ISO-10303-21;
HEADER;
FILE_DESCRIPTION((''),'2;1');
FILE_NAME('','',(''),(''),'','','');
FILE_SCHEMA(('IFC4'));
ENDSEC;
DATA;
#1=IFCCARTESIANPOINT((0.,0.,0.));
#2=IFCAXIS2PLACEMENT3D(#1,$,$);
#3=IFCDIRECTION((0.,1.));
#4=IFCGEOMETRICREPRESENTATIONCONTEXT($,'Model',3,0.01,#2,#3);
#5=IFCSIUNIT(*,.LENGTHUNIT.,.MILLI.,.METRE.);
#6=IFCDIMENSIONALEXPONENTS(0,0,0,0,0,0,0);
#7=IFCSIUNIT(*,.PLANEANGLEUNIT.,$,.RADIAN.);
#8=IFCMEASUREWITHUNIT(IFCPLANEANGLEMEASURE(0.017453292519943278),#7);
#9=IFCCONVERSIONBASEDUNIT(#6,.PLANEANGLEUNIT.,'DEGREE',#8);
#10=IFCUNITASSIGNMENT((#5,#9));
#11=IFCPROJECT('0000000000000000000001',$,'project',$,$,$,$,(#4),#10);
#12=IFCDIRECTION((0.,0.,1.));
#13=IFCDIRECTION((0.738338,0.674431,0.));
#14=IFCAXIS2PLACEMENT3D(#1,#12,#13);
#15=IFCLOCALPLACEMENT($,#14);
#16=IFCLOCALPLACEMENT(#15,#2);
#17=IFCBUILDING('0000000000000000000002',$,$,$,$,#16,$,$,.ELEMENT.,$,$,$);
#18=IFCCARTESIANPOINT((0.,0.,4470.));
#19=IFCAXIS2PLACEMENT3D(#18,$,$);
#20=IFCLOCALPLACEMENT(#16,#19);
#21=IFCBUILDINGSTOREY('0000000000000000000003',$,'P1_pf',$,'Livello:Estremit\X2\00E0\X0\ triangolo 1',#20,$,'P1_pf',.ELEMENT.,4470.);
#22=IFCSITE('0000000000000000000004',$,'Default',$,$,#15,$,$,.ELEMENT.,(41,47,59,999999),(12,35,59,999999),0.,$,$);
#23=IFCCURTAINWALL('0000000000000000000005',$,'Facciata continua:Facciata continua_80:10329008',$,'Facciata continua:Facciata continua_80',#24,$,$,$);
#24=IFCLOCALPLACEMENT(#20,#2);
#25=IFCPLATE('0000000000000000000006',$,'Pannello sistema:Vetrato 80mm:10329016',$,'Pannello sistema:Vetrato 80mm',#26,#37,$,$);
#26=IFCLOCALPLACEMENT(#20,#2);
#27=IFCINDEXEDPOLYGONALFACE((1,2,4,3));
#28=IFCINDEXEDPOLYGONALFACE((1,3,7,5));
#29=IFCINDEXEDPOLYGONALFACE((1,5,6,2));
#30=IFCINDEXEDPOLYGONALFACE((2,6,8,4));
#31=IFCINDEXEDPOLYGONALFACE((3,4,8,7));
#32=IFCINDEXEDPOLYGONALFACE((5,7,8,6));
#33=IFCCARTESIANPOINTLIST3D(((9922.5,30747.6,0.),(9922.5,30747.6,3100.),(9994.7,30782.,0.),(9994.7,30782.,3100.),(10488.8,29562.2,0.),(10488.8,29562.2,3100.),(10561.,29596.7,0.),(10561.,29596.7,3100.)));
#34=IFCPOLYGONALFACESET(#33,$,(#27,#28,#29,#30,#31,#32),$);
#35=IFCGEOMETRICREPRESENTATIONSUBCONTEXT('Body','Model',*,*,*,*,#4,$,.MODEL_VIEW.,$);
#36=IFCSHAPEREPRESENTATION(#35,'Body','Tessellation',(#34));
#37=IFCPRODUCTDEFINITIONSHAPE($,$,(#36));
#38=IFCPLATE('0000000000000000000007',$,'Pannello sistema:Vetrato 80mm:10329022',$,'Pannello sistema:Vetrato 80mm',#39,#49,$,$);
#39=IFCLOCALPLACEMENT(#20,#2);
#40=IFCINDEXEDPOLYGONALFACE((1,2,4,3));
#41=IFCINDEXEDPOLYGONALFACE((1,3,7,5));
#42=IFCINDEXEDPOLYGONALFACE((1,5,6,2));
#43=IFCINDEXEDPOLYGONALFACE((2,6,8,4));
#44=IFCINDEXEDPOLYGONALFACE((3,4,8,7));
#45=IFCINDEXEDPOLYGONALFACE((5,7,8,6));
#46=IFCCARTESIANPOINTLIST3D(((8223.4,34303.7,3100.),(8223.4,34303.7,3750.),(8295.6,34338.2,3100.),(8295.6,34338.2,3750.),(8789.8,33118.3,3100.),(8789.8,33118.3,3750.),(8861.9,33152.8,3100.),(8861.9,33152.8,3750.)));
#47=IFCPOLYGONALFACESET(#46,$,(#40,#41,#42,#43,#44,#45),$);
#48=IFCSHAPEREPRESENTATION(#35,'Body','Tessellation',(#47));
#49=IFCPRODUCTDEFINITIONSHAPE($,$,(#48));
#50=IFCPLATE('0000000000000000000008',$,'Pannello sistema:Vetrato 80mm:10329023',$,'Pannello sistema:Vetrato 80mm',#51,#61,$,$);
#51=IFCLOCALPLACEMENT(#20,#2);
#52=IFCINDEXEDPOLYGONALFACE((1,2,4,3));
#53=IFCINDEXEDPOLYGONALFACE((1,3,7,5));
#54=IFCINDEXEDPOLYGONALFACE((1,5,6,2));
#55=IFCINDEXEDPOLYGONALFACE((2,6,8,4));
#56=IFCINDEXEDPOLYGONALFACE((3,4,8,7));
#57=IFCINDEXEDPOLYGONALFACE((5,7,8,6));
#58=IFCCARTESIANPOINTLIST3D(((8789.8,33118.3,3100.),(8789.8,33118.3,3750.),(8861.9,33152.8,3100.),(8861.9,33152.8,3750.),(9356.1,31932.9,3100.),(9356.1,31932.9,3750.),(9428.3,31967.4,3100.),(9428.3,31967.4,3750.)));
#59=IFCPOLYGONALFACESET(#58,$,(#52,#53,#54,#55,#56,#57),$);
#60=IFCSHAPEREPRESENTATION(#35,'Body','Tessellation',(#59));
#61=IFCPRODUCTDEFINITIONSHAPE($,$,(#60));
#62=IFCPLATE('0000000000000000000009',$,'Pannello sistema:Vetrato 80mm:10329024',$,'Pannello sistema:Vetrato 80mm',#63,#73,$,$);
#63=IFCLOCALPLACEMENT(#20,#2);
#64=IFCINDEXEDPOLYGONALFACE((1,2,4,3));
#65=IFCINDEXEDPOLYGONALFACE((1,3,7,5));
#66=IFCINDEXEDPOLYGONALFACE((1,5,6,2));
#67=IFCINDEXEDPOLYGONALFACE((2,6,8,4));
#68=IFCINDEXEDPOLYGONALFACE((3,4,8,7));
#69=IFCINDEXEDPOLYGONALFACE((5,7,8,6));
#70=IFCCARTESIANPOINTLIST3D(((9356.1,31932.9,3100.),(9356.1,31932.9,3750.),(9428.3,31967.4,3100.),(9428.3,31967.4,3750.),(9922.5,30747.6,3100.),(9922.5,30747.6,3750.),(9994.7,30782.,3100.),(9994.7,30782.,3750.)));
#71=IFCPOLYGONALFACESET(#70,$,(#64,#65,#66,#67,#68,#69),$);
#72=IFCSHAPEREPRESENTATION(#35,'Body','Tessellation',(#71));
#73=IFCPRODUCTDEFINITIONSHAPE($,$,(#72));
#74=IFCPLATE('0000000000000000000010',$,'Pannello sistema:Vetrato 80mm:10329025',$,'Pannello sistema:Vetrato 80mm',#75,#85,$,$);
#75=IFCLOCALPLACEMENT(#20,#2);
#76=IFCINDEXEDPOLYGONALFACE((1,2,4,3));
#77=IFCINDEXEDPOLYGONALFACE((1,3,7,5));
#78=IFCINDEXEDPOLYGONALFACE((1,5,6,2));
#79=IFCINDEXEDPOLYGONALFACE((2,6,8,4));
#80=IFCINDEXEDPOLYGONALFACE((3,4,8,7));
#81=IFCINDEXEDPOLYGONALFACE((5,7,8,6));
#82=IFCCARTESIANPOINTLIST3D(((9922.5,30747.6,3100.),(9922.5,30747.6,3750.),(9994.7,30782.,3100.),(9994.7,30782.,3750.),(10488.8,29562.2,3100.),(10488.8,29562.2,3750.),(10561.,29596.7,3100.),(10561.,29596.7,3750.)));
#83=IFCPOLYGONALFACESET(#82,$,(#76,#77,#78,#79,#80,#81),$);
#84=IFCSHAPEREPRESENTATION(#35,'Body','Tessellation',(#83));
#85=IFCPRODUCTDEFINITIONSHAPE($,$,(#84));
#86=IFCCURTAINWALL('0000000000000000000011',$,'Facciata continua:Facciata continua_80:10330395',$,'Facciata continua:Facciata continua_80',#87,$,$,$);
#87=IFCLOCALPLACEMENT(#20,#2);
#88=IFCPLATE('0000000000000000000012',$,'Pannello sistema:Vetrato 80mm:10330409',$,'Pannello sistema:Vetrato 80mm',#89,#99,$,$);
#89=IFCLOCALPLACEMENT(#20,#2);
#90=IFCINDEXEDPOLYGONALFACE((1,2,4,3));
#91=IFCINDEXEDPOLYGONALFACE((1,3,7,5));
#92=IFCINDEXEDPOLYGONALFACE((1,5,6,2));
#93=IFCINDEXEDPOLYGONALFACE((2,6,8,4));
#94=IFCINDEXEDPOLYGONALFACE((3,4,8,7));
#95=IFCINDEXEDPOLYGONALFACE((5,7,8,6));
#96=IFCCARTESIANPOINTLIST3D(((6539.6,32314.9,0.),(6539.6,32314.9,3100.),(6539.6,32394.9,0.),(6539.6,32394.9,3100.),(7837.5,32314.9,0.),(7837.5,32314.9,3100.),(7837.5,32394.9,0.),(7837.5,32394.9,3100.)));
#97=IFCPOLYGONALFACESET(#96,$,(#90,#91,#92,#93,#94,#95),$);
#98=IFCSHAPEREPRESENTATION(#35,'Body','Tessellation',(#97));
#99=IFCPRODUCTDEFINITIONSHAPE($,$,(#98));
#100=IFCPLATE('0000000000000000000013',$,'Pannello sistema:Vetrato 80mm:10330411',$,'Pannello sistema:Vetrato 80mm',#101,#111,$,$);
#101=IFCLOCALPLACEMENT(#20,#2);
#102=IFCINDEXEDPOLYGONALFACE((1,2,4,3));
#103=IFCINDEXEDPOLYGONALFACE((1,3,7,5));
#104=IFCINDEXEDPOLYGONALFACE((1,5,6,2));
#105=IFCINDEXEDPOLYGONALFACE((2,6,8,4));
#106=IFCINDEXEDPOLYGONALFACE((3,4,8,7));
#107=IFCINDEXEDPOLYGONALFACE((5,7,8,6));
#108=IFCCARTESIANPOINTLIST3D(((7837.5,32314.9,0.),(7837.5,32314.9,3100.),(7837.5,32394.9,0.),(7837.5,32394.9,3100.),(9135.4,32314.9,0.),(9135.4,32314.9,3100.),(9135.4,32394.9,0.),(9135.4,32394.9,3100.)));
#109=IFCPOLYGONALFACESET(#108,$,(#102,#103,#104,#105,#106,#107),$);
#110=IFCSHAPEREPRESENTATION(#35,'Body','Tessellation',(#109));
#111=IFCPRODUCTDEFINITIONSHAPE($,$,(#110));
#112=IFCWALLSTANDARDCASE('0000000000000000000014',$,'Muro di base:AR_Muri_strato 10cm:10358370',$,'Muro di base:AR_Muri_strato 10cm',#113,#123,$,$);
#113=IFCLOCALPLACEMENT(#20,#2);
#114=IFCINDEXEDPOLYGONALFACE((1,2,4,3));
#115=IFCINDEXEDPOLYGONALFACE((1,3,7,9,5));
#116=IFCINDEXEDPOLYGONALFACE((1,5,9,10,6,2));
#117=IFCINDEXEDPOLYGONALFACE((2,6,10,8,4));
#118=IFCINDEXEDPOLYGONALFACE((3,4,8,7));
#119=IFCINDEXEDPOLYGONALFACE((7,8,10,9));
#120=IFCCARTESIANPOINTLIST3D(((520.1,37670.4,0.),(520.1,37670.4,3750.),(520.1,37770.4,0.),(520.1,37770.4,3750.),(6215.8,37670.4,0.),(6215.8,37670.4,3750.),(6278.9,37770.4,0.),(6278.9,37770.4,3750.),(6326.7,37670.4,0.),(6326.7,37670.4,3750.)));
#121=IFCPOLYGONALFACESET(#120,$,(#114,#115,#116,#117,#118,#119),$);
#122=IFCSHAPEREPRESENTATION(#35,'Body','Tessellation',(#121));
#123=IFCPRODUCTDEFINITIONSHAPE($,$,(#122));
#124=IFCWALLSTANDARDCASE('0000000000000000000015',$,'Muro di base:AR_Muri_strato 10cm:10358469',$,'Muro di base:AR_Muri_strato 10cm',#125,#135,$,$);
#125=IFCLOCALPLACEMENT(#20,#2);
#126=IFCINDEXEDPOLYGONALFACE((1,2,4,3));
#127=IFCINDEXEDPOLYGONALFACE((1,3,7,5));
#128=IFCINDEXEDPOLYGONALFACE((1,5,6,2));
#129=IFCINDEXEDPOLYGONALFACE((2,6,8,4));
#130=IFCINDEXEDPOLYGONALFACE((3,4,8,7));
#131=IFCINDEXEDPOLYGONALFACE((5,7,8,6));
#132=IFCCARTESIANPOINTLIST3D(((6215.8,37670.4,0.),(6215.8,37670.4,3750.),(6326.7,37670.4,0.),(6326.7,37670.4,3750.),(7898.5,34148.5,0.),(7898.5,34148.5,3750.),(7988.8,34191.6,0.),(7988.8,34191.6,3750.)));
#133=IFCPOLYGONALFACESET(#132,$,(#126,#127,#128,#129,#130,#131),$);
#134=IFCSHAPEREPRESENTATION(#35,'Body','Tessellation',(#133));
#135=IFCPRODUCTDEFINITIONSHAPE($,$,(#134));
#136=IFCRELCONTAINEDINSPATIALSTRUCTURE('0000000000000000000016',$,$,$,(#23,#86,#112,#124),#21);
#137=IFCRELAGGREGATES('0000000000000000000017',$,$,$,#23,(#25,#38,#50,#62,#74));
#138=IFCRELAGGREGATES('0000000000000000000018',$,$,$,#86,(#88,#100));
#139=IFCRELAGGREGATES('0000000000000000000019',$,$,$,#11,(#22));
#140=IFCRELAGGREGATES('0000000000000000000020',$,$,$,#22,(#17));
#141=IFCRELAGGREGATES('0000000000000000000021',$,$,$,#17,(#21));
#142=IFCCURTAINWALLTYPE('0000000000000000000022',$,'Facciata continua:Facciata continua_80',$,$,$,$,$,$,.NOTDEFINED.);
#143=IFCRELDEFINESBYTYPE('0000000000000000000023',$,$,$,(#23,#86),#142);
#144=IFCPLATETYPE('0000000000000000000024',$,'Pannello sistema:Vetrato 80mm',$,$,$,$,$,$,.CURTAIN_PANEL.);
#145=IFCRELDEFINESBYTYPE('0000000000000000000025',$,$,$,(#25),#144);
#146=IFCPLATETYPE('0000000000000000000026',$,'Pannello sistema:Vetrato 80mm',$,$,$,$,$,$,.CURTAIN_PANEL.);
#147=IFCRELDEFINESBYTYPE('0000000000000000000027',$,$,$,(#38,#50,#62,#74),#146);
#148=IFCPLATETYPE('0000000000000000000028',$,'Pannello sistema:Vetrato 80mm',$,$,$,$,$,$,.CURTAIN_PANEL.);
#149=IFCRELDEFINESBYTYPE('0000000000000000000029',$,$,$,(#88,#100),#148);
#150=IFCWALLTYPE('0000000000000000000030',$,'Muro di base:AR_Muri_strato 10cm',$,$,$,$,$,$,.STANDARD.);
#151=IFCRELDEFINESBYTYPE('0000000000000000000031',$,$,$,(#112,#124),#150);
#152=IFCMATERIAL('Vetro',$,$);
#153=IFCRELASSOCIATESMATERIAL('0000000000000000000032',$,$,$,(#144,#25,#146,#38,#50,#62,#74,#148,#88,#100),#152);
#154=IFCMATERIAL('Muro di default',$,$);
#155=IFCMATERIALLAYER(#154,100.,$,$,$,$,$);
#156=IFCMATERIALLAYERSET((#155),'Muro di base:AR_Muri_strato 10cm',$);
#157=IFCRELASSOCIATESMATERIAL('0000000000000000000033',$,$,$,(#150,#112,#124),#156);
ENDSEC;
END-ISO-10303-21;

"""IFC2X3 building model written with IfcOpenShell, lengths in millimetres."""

from ifc_helpers import new_model, entity, si_unit, converted_unit, direction, frame, frame_2d, origin, origin_2d_with_axis, place, context, subcontext, project, spatial, polyline, rectangle, outline, extrude, source, transform, mapped, material, layer, layer_set, layer_usage, type_object, type_shapes, element, aggregate, save


model = new_model("IFC2X3")

# Units and contexts
model_context = context("Model", 3, precision=0.01, world=origin(), true_north=direction((0.0, 1.0)))
body_context = subcontext(model_context, "Body", "Model", "MODEL_VIEW")
ifc_project = project(units=[si_unit("LENGTHUNIT", "METRE", prefix="MILLI"), converted_unit("PLANEANGLEUNIT", "DEGREE", entity("IfcPlaneAngleMeasure", 0.017453292519943278), si_unit("PLANEANGLEUNIT", "RADIAN"), dimensions=[0, 0, 0, 0, 0, 0, 0])], contexts=[model_context])

# Site, building, storey
site_placement = place(None, frame((0.0, 0.0, 0.0), z_axis=(0.0, 0.0, 1.0), x_axis=(0.738338, 0.674431, 0.0)))
site = spatial("IfcSite", under=ifc_project, at=site_placement, Name="Default", CompositionType="ELEMENT", RefLatitude=(41, 47, 59, 999999), RefLongitude=(12, 35, 59, 999999), RefElevation=0.0)
building_placement = place(site_placement, origin())
building = spatial("IfcBuilding", under=site, at=building_placement, CompositionType="ELEMENT")
storey_placement = place(building_placement, frame((0.0, 0.0, 4470.0)))
storey = spatial("IfcBuildingStorey", under=building, at=storey_placement, Name="P1_pf", ObjectType="Livello:Estremità triangolo 1", LongName="P1_pf", CompositionType="ELEMENT", Elevation=4470.0)

# Curtain walls, plates
curtain_wall_type = type_object("IfcCurtainWallType", Name="Facciata continua:Facciata continua_80", PredefinedType="NOTDEFINED")
ifc_material_1 = material(Name="Vetro")
curtain_wall_1_placement = place(storey_placement, frame((0.0, 0.0, -4470.0)))
curtain_wall_1 = element("IfcCurtainWall", 1, at=curtain_wall_1_placement, inside=storey, type_object=curtain_wall_type, Name="Facciata continua:Facciata continua_80:10329008", ObjectType="Facciata continua:Facciata continua_80")
plate_type_1 = type_object("IfcPlateType", Name="Pannello sistema:Vetrato 80mm", PredefinedType="CURTAIN_PANEL", material=ifc_material_1)
shared_shape_1 = source(origin(), body_context, "Body", "SweptSolid", [
    extrude(rectangle(XDim=80.0, YDim=1313.7, at=frame_2d((0.0, 0.0), x_axis=(1.0, 0.0))), frame((0.0, -40.0, 0.0), z_axis=(0.0, 0.0, 1.0), x_axis=(0.0, 1.0, 0.0)), (0.0, 0.0, 1.0), 3100.0),
])
type_shapes(plate_type_1, [shared_shape_1])
plate_1_placement = place(curtain_wall_1_placement, frame((10277.8, 30189.4, 4470.0), z_axis=(0.0, 0.0, 1.0), x_axis=(0.431105, -0.902302, 0.0)))
plate_1 = element("IfcPlate", 2, at=plate_1_placement, type_object=plate_type_1, material=ifc_material_1, Name="Pannello sistema:Vetrato 80mm:10329016", ObjectType="Pannello sistema:Vetrato 80mm", context=body_context, shape_type="MappedRepresentation", body=[
    mapped(shared_shape_1, transform((0.0, 0.0, 0.0), scale=1.0)),
])
plate_type_2 = type_object("IfcPlateType", Name="Pannello sistema:Vetrato 80mm", PredefinedType="CURTAIN_PANEL", material=ifc_material_1)
shared_shape_2 = source(origin(), body_context, "Body", "SweptSolid", [
    extrude(rectangle(XDim=80.0, YDim=1313.7, at=frame_2d((0.0, 0.0), x_axis=(1.0, 0.0))), frame((0.0, -40.0, 0.0), z_axis=(0.0, 0.0, 1.0), x_axis=(0.0, 1.0, 0.0)), (0.0, 0.0, 1.0), 650.0),
])
type_shapes(plate_type_2, [shared_shape_2])
plate_2_placement = place(curtain_wall_1_placement, frame((8578.8, 33745.5, 7570.0), z_axis=(0.0, 0.0, 1.0), x_axis=(0.431105, -0.902302, 0.0)))
plate_2 = element("IfcPlate", 3, at=plate_2_placement, type_object=plate_type_2, material=ifc_material_1, Name="Pannello sistema:Vetrato 80mm:10329022", ObjectType="Pannello sistema:Vetrato 80mm", context=body_context, shape_type="MappedRepresentation", body=[
    mapped(shared_shape_2, transform((0.0, 0.0, 0.0), scale=1.0)),
])
plate_3_placement = place(curtain_wall_1_placement, frame((9145.1, 32560.1, 7570.0), z_axis=(0.0, 0.0, 1.0), x_axis=(0.431105, -0.902302, 0.0)))
plate_3 = element("IfcPlate", 4, at=plate_3_placement, type_object=plate_type_2, material=ifc_material_1, Name="Pannello sistema:Vetrato 80mm:10329023", ObjectType="Pannello sistema:Vetrato 80mm", context=body_context, shape_type="MappedRepresentation", body=[
    mapped(shared_shape_2, transform((0.0, 0.0, 0.0), scale=1.0)),
])
plate_4_placement = place(curtain_wall_1_placement, frame((9711.5, 31374.7, 7570.0), z_axis=(0.0, 0.0, 1.0), x_axis=(0.431105, -0.902302, 0.0)))
plate_4 = element("IfcPlate", 5, at=plate_4_placement, type_object=plate_type_2, material=ifc_material_1, Name="Pannello sistema:Vetrato 80mm:10329024", ObjectType="Pannello sistema:Vetrato 80mm", context=body_context, shape_type="MappedRepresentation", body=[
    mapped(shared_shape_2, transform((0.0, 0.0, 0.0), scale=1.0)),
])
plate_5_placement = place(curtain_wall_1_placement, frame((10277.8, 30189.4, 7570.0), z_axis=(0.0, 0.0, 1.0), x_axis=(0.431105, -0.902302, 0.0)))
plate_5 = element("IfcPlate", 6, at=plate_5_placement, type_object=plate_type_2, material=ifc_material_1, Name="Pannello sistema:Vetrato 80mm:10329025", ObjectType="Pannello sistema:Vetrato 80mm", context=body_context, shape_type="MappedRepresentation", body=[
    mapped(shared_shape_2, transform((0.0, 0.0, 0.0), scale=1.0)),
])
aggregate(curtain_wall_1, [plate_1, plate_2, plate_3, plate_4, plate_5])
curtain_wall_2_placement = place(storey_placement, frame((0.0, 0.0, -4470.0)))
curtain_wall_2 = element("IfcCurtainWall", 7, at=curtain_wall_2_placement, inside=storey, type_object=curtain_wall_type, Name="Facciata continua:Facciata continua_80:10330395", ObjectType="Facciata continua:Facciata continua_80")
plate_type_3 = type_object("IfcPlateType", Name="Pannello sistema:Vetrato 80mm", PredefinedType="CURTAIN_PANEL", material=ifc_material_1)
shared_shape_3 = source(origin(), body_context, "Body", "SweptSolid", [
    extrude(rectangle(XDim=80.0, YDim=1297.9, at=origin_2d_with_axis()), frame((0.0, -40.0, 0.0), z_axis=(0.0, 0.0, 1.0), x_axis=(0.0, 1.0, 0.0)), (0.0, 0.0, 1.0), 3100.0),
])
type_shapes(plate_type_3, [shared_shape_3])
plate_6_placement = place(curtain_wall_2_placement, frame((7188.5, 32394.9, 4470.0)))
plate_6 = element("IfcPlate", 8, at=plate_6_placement, type_object=plate_type_3, material=ifc_material_1, Name="Pannello sistema:Vetrato 80mm:10330409", ObjectType="Pannello sistema:Vetrato 80mm", context=body_context, shape_type="MappedRepresentation", body=[
    mapped(shared_shape_3, transform((0.0, 0.0, 0.0), scale=1.0)),
])
plate_7_placement = place(curtain_wall_2_placement, frame((8486.4, 32394.9, 4470.0)))
plate_7 = element("IfcPlate", 9, at=plate_7_placement, type_object=plate_type_3, material=ifc_material_1, Name="Pannello sistema:Vetrato 80mm:10330411", ObjectType="Pannello sistema:Vetrato 80mm", context=body_context, shape_type="MappedRepresentation", body=[
    mapped(shared_shape_3, transform((0.0, 0.0, 0.0), scale=1.0)),
])
aggregate(curtain_wall_2, [plate_6, plate_7])

# Walls
ifc_material_2 = material(Name="Muro di default")
ifc_layer = layer(ifc_material_2, 100.0)
ifc_layer_set = layer_set([ifc_layer], Name="Muro di base:AR_Muri_strato 10cm")
ifc_layer_usage_1 = layer_usage(ifc_layer_set, "AXIS2", "NEGATIVE", 50.0)
wall_type = type_object("IfcWallType", Name="Muro di base:AR_Muri_strato 10cm", PredefinedType="STANDARD", material=ifc_layer_set)
wall_1_placement = place(storey_placement, frame((520.1, 37720.4, 0.0)))
element("IfcWallStandardCase", 10, at=wall_1_placement, inside=storey, type_object=wall_type, material=ifc_layer_usage_1, Name="Muro di base:AR_Muri_strato 10cm:10358370", ObjectType="Muro di base:AR_Muri_strato 10cm", context=body_context, shape_type="SweptSolid", body=[
    extrude(outline(polyline([(5806.6, -50.0), (5758.8, 50.0), (0.0, 50.0), (0.0, -50.0), (5695.7, -50.0), (5806.6, -50.0)])), origin(), (0.0, 0.0, 1.0), 3750.0),
])
ifc_layer_usage_2 = layer_usage(ifc_layer_set, "AXIS2", "NEGATIVE", 50.0)
wall_2_placement = place(storey_placement, frame((6260.9, 37691.9, 0.0), z_axis=(0.0, 0.0, 1.0), x_axis=(0.431105, -0.902302, 0.0)))
element("IfcWallStandardCase", 11, at=wall_2_placement, inside=storey, type_object=wall_type, material=ifc_layer_usage_2, Name="Muro di base:AR_Muri_strato 10cm:10358469", ObjectType="Muro di base:AR_Muri_strato 10cm", context=body_context, shape_type="SweptSolid", body=[
    extrude(outline(polyline([(3903.2, -50.0), (3903.2, 50.0), (47.8, 50.0), (0.0, -50.0), (3903.2, -50.0)])), origin(), (0.0, 0.0, 1.0), 3750.0),
])

save(model, "model.ifc")
